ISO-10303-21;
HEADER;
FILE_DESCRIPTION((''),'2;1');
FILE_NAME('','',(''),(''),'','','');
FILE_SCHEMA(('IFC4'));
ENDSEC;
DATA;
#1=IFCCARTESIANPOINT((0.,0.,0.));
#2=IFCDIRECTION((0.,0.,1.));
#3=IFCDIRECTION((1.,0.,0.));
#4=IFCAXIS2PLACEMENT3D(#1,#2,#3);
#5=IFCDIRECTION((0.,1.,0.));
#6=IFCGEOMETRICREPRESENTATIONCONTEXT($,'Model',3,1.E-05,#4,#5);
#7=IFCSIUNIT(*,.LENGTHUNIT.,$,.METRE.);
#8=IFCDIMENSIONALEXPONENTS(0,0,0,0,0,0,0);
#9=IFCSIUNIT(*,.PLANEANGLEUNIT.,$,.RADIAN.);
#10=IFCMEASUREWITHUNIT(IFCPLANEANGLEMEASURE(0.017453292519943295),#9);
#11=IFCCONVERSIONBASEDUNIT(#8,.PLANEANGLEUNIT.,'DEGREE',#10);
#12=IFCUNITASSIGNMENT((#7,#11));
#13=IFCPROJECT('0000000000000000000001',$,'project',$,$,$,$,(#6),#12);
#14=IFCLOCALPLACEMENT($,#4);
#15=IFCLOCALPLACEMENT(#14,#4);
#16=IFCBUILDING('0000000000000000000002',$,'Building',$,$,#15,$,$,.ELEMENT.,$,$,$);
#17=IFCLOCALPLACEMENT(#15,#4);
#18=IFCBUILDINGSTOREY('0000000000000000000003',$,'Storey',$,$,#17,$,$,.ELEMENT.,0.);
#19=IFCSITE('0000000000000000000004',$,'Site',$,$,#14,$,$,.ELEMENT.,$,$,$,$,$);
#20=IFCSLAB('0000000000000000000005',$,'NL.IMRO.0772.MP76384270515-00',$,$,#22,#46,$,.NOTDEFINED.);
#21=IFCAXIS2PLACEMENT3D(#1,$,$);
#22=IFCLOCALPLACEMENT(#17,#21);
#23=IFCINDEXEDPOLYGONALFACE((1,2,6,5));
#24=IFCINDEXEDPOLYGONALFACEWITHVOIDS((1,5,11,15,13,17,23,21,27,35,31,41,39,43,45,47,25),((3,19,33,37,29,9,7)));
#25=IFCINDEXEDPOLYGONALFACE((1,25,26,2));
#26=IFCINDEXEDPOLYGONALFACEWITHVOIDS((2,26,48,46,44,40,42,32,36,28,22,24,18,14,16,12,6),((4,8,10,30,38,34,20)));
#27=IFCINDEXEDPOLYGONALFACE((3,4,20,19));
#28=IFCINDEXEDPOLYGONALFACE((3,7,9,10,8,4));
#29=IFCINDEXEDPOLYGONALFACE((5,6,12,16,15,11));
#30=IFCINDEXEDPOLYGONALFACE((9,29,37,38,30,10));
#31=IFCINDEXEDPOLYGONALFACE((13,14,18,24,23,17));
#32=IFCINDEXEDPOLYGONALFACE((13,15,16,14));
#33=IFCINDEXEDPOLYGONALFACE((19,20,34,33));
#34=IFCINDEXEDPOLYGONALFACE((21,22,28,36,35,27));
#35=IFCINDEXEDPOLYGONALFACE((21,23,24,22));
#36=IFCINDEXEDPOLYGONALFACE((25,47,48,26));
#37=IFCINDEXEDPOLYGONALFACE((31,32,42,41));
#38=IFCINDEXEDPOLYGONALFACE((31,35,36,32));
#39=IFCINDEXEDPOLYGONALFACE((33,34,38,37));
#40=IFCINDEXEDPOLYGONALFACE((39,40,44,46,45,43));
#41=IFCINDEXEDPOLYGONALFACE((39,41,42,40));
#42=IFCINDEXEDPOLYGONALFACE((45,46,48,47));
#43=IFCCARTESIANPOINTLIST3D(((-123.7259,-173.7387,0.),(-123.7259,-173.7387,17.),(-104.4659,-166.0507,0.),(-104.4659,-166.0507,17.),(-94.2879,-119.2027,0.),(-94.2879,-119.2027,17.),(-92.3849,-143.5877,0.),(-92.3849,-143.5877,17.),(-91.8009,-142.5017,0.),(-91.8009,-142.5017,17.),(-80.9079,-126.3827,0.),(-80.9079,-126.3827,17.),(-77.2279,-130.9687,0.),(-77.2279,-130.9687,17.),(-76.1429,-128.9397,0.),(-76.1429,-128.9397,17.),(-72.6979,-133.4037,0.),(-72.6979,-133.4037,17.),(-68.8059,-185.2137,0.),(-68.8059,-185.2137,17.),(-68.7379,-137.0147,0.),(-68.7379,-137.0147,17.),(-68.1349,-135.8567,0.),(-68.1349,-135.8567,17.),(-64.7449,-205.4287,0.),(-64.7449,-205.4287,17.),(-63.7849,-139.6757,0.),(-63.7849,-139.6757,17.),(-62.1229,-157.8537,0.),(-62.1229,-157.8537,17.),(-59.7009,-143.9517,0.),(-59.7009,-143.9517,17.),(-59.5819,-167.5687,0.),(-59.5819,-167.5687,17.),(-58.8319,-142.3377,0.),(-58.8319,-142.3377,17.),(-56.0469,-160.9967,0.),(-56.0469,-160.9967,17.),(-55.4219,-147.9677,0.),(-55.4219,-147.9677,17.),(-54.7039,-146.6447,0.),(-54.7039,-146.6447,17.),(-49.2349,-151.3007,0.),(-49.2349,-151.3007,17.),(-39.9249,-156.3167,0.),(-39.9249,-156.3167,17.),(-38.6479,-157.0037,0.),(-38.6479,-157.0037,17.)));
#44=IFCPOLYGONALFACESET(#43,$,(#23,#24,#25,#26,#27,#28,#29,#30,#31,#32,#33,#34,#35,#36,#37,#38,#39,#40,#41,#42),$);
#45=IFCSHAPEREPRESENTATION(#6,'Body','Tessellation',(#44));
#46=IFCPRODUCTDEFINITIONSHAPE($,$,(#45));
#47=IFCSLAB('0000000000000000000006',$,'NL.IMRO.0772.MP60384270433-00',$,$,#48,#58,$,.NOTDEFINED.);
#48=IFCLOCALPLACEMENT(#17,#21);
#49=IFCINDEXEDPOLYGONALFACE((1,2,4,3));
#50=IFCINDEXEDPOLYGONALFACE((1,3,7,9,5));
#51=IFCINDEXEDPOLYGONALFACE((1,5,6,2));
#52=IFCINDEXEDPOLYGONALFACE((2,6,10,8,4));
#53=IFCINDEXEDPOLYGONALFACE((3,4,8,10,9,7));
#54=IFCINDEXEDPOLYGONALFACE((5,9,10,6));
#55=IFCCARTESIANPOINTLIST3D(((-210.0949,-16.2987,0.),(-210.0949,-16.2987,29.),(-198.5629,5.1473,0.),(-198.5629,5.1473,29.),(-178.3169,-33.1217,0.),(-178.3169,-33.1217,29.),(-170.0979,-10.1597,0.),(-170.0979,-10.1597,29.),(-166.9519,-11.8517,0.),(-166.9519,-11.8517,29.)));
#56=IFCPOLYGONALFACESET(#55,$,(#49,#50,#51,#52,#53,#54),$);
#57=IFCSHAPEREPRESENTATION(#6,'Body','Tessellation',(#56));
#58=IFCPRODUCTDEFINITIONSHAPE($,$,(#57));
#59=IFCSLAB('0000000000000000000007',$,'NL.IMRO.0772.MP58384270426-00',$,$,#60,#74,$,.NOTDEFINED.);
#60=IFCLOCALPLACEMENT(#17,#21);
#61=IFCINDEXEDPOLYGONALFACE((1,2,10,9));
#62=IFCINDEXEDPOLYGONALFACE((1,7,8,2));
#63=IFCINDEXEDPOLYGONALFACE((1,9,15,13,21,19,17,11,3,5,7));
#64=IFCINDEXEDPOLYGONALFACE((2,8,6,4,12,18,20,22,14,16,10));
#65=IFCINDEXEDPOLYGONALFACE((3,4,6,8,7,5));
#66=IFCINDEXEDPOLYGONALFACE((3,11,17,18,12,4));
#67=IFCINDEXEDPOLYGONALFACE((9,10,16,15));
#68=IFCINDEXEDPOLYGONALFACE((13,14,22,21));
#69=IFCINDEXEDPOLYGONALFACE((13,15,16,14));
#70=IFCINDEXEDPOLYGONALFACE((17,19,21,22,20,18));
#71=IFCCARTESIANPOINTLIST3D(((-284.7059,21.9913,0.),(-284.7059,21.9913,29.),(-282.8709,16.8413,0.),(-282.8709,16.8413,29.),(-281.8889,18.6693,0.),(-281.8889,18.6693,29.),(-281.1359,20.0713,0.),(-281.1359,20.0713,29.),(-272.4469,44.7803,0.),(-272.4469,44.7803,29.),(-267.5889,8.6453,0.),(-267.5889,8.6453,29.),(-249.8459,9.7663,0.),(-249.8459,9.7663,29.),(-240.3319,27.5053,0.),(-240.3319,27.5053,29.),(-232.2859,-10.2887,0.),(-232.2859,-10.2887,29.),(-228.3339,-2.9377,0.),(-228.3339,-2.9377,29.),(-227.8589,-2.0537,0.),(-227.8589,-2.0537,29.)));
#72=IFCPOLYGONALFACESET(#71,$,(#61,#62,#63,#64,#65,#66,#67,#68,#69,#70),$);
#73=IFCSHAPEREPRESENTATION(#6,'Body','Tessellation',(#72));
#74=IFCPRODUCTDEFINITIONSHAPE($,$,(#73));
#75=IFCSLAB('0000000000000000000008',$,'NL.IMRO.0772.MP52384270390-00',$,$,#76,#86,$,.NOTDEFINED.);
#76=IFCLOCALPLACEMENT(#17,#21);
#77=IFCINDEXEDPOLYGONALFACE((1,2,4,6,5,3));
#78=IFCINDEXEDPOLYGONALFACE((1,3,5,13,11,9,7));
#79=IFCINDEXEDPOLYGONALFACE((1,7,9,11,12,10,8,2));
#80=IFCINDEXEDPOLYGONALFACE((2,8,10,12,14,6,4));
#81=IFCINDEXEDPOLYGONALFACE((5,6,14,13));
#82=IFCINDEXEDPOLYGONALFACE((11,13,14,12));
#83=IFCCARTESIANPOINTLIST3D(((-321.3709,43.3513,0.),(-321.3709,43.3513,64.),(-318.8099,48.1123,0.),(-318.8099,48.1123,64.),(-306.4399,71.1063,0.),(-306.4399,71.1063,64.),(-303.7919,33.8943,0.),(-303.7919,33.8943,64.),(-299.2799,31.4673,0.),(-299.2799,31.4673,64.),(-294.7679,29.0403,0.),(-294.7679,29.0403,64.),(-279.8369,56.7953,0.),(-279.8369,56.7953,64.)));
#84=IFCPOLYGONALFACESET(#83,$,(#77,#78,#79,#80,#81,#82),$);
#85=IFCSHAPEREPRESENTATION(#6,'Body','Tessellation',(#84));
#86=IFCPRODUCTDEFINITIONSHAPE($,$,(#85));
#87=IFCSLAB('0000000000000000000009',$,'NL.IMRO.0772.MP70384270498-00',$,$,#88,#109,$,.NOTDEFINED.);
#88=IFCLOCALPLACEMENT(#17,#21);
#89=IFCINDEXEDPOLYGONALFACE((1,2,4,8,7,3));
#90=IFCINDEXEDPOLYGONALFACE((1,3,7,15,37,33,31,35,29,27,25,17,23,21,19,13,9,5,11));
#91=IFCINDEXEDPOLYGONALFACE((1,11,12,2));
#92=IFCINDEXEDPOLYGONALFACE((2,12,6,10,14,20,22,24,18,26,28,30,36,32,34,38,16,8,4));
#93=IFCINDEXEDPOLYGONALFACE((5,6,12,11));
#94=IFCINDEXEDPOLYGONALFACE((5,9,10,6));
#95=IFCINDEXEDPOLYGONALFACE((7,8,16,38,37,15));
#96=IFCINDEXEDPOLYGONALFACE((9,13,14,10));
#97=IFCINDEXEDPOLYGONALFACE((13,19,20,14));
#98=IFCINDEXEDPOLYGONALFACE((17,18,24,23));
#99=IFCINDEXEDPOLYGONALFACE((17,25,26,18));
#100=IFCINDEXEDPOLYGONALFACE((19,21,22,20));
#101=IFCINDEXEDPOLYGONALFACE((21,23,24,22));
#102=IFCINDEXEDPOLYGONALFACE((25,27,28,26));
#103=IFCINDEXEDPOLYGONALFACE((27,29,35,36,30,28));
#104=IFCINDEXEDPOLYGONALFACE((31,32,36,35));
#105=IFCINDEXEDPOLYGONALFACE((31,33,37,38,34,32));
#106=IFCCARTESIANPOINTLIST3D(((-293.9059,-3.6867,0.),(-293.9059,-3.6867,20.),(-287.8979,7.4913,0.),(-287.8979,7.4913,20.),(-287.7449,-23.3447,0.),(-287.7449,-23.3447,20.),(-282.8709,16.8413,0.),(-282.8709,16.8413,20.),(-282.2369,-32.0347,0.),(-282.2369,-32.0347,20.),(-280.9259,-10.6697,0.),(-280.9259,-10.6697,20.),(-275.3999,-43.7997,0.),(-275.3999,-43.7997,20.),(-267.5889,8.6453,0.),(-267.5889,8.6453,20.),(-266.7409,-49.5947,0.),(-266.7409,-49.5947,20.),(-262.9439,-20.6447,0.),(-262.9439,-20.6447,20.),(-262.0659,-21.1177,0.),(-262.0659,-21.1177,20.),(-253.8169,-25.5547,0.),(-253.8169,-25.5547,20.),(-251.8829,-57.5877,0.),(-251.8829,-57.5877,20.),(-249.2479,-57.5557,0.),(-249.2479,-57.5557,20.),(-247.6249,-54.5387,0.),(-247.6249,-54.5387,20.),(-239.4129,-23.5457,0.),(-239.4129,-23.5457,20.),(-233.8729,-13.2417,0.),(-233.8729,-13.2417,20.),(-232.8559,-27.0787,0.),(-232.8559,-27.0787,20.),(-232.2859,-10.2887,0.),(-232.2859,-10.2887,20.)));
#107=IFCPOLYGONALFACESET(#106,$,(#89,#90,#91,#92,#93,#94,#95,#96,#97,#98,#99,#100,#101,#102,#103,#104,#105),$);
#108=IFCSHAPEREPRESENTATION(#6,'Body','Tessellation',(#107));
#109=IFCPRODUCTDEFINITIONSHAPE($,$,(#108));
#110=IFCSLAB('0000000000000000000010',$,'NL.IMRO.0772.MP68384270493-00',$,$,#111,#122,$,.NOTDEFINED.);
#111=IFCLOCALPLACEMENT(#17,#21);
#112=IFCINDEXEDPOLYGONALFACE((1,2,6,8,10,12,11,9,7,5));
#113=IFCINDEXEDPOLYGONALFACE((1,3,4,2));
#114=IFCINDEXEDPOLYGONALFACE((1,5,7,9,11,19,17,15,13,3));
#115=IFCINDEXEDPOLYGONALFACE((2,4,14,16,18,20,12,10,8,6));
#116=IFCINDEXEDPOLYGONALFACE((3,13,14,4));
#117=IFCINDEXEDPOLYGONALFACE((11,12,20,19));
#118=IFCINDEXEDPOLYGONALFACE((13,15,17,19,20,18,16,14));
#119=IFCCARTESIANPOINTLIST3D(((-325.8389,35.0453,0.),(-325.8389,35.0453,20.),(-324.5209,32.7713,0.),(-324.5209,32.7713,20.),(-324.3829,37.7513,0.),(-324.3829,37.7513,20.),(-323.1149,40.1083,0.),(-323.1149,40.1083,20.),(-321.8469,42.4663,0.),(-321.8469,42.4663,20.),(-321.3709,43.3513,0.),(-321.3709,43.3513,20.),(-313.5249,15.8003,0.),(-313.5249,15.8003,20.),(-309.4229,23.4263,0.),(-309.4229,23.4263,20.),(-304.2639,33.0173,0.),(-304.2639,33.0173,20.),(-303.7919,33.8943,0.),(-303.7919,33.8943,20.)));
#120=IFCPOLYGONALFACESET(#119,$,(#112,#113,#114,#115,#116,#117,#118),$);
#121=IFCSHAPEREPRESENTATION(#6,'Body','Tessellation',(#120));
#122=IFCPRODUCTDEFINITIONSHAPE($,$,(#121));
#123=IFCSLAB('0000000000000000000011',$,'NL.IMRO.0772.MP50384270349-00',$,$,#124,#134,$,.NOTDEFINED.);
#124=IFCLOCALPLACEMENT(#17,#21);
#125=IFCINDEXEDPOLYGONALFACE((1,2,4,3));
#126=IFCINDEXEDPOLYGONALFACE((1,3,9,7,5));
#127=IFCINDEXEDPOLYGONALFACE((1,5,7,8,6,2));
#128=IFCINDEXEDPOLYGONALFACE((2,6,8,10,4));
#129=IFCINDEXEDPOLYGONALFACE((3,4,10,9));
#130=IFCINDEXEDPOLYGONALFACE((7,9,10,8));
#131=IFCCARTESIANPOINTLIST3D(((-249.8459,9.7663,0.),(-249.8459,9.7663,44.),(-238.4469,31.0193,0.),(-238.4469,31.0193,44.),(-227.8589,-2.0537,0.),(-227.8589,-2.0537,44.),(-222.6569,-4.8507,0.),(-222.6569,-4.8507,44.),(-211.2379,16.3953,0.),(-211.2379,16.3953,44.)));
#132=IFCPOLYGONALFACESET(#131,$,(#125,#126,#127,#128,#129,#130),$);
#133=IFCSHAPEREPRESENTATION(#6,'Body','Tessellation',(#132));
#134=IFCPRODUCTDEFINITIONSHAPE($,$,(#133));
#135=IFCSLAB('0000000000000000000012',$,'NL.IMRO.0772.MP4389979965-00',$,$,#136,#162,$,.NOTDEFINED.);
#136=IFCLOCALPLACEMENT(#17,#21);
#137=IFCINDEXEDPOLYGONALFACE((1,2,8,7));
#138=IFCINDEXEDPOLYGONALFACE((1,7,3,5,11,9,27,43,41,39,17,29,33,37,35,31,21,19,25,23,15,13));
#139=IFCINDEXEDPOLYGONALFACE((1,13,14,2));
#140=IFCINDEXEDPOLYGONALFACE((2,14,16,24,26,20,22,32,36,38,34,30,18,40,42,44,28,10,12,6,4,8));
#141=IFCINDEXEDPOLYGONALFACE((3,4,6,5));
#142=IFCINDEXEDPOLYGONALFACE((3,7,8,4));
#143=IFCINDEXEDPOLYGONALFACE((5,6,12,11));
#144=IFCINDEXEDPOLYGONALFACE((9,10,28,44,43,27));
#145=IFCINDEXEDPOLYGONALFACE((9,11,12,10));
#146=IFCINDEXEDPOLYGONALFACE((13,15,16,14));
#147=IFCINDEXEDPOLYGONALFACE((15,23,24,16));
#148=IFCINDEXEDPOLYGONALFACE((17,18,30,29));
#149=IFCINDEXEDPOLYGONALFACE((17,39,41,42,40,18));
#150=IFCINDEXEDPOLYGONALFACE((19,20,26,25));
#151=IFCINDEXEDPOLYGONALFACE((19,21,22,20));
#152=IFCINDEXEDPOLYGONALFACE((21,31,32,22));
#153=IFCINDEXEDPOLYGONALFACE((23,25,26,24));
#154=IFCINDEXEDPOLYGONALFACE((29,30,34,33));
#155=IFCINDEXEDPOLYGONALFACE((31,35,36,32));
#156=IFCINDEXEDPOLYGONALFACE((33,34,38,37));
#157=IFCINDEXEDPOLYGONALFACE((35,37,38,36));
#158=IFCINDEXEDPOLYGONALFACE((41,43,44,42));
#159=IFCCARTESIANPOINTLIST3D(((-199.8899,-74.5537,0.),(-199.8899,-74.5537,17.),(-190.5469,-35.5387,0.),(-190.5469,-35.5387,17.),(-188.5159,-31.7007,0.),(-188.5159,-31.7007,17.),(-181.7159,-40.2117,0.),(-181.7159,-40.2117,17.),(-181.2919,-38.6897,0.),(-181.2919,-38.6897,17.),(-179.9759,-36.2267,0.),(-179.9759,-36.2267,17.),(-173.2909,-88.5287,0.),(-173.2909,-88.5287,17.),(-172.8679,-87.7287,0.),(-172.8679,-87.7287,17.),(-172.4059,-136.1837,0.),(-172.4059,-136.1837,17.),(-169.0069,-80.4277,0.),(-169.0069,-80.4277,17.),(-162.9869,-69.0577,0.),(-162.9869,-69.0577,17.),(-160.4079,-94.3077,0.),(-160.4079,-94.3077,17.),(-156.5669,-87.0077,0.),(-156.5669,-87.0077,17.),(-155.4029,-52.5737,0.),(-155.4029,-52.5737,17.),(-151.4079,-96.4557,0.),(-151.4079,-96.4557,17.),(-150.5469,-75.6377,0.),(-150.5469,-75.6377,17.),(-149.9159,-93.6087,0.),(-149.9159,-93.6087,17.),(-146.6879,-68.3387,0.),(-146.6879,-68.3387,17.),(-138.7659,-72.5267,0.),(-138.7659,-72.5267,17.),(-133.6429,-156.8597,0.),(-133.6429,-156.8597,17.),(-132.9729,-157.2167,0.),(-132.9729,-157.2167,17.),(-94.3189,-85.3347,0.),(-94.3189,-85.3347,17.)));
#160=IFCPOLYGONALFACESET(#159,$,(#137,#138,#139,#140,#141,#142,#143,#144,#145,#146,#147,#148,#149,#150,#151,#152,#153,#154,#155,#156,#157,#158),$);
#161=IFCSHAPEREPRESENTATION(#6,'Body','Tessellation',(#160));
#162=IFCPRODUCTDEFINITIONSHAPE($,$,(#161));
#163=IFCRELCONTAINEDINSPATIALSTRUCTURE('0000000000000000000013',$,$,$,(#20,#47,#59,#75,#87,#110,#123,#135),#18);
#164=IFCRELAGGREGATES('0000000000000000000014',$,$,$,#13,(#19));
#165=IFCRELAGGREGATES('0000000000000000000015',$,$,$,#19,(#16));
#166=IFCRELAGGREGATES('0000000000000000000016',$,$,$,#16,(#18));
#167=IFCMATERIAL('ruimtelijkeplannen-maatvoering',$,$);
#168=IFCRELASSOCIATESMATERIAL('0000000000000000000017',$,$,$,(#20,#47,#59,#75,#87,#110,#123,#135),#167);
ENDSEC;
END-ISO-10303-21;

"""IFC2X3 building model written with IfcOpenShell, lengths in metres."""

from ifc_helpers import new_model, entity, si_unit, converted_unit, direction, origin_with_axes, place, context, project, spatial, polyline, outline, extrude, material, element, save


model = new_model("IFC2X3")

# Units and contexts
model_context = context("Model", 3, precision=1e-05, world=origin_with_axes(), true_north=direction((0.0, 1.0, 0.0)))
ifc_project = project(units=[si_unit("LENGTHUNIT", "METRE"), converted_unit("PLANEANGLEUNIT", "DEGREE", entity("IfcPlaneAngleMeasure", 0.017453292519943295), si_unit("PLANEANGLEUNIT", "RADIAN"), dimensions=[0, 0, 0, 0, 0, 0, 0])], contexts=[model_context])

# Site, building, storey
site_placement = place(None, origin_with_axes())
site = spatial("IfcSite", under=ifc_project, at=site_placement, Name="Site", CompositionType="ELEMENT")
building_placement = place(site_placement, origin_with_axes())
building = spatial("IfcBuilding", under=site, at=building_placement, Name="Building", CompositionType="ELEMENT")
storey_placement = place(building_placement, origin_with_axes())
storey = spatial("IfcBuildingStorey", under=building, at=storey_placement, Name="Storey", CompositionType="ELEMENT", Elevation=0.0)

# Slabs
ifc_material = material(Name="ruimtelijkeplannen-maatvoering")
slab_1_placement = place(storey_placement, origin_with_axes())
element("IfcSlab", 1, at=slab_1_placement, inside=storey, material=ifc_material, Name="NL.IMRO.0772.MP76384270515-00", PredefinedType="NOTDEFINED", context=model_context, shape_type="SweptSolid", body=[
    extrude(outline(polyline([(-123.7259, -173.7387), (-94.2879, -119.2027), (-80.9079, -126.3827), (-76.1429, -128.9397), (-77.2279, -130.9687), (-72.6979, -133.4037), (-68.1349, -135.8567), (-68.7379, -137.0147), (-63.7849, -139.6757), (-58.8319, -142.3377), (-59.7009, -143.9517), (-54.7039, -146.6447), (-55.4219, -147.9677), (-49.2349, -151.3007), (-39.9249, -156.3167), (-38.6479, -157.0037), (-64.7449, -205.4287), (-123.7259, -173.7387)]), holes=[polyline([(-92.3849, -143.5877), (-104.4659, -166.0507), (-68.8059, -185.2137), (-59.5819, -167.5687), (-56.0469, -160.9967), (-62.1229, -157.8537), (-91.8009, -142.5017), (-92.3849, -143.5877)])]), origin_with_axes(), (0.0, 0.0, 1.0), 17.0),
])
slab_2_placement = place(storey_placement, origin_with_axes())
element("IfcSlab", 2, at=slab_2_placement, inside=storey, material=ifc_material, Name="NL.IMRO.0772.MP60384270433-00", PredefinedType="NOTDEFINED", context=model_context, shape_type="SweptSolid", body=[
    extrude(outline(polyline([(-178.3169, -33.1217), (-210.0949, -16.2987), (-198.5629, 5.1473), (-170.0979, -10.1597), (-166.9519, -11.8517), (-178.3169, -33.1217)])), origin_with_axes(), (0.0, 0.0, 1.0), 29.0),
])
slab_3_placement = place(storey_placement, origin_with_axes())
element("IfcSlab", 3, at=slab_3_placement, inside=storey, material=ifc_material, Name="NL.IMRO.0772.MP58384270426-00", PredefinedType="NOTDEFINED", context=model_context, shape_type="SweptSolid", body=[
    extrude(outline(polyline([(-282.8709, 16.8413), (-281.8889, 18.6693), (-281.1359, 20.0713), (-284.7059, 21.9913), (-272.4469, 44.7803), (-240.3319, 27.5053), (-249.8459, 9.7663), (-227.8589, -2.0537), (-228.3339, -2.9377), (-232.2859, -10.2887), (-267.5889, 8.6453), (-282.8709, 16.8413)])), origin_with_axes(), (0.0, 0.0, 1.0), 29.0),
])
slab_4_placement = place(storey_placement, origin_with_axes())
element("IfcSlab", 4, at=slab_4_placement, inside=storey, material=ifc_material, Name="NL.IMRO.0772.MP52384270390-00", PredefinedType="NOTDEFINED", context=model_context, shape_type="SweptSolid", body=[
    extrude(outline(polyline([(-306.4399, 71.1063), (-279.8369, 56.7953), (-294.7679, 29.0403), (-299.2799, 31.4673), (-303.7919, 33.8943), (-321.3709, 43.3513), (-318.8099, 48.1123), (-306.4399, 71.1063)])), origin_with_axes(), (0.0, 0.0, 1.0), 64.0),
])
slab_5_placement = place(storey_placement, origin_with_axes())
element("IfcSlab", 5, at=slab_5_placement, inside=storey, material=ifc_material, Name="NL.IMRO.0772.MP70384270498-00", PredefinedType="NOTDEFINED", context=model_context, shape_type="SweptSolid", body=[
    extrude(outline(polyline([(-232.2859, -10.2887), (-233.8729, -13.2417), (-239.4129, -23.5457), (-232.8559, -27.0787), (-247.6249, -54.5387), (-249.2479, -57.5557), (-251.8829, -57.5877), (-266.7409, -49.5947), (-253.8169, -25.5547), (-262.0659, -21.1177), (-262.9439, -20.6447), (-275.3999, -43.7997), (-282.2369, -32.0347), (-287.7449, -23.3447), (-280.9259, -10.6697), (-293.9059, -3.6867), (-287.8979, 7.4913), (-282.8709, 16.8413), (-267.5889, 8.6453), (-232.2859, -10.2887)])), origin_with_axes(), (0.0, 0.0, 1.0), 20.0),
])
slab_6_placement = place(storey_placement, origin_with_axes())
element("IfcSlab", 6, at=slab_6_placement, inside=storey, material=ifc_material, Name="NL.IMRO.0772.MP68384270493-00", PredefinedType="NOTDEFINED", context=model_context, shape_type="SweptSolid", body=[
    extrude(outline(polyline([(-321.3709, 43.3513), (-303.7919, 33.8943), (-304.2639, 33.0173), (-309.4229, 23.4263), (-313.5249, 15.8003), (-324.5209, 32.7713), (-325.8389, 35.0453), (-324.3829, 37.7513), (-323.1149, 40.1083), (-321.8469, 42.4663), (-321.3709, 43.3513)])), origin_with_axes(), (0.0, 0.0, 1.0), 20.0),
])
slab_7_placement = place(storey_placement, origin_with_axes())
element("IfcSlab", 7, at=slab_7_placement, inside=storey, material=ifc_material, Name="NL.IMRO.0772.MP50384270349-00", PredefinedType="NOTDEFINED", context=model_context, shape_type="SweptSolid", body=[
    extrude(outline(polyline([(-238.4469, 31.0193), (-211.2379, 16.3953), (-222.6569, -4.8507), (-227.8589, -2.0537), (-249.8459, 9.7663), (-238.4469, 31.0193)])), origin_with_axes(), (0.0, 0.0, 1.0), 44.0),
])
slab_8_placement = place(storey_placement, origin_with_axes())
element("IfcSlab", 8, at=slab_8_placement, inside=storey, material=ifc_material, Name="NL.IMRO.0772.MP4389979965-00", PredefinedType="NOTDEFINED", context=model_context, shape_type="SweptSolid", body=[
    extrude(outline(polyline([(-138.7659, -72.5267), (-146.6879, -68.3387), (-150.5469, -75.6377), (-162.9869, -69.0577), (-169.0069, -80.4277), (-156.5669, -87.0077), (-160.4079, -94.3077), (-172.8679, -87.7287), (-173.2909, -88.5287), (-199.8899, -74.5537), (-181.7159, -40.2117), (-190.5469, -35.5387), (-188.5159, -31.7007), (-179.9759, -36.2267), (-181.2919, -38.6897), (-155.4029, -52.5737), (-94.3189, -85.3347), (-132.9729, -157.2167), (-133.6429, -156.8597), (-172.4059, -136.1837), (-151.4079, -96.4557), (-149.9159, -93.6087), (-138.7659, -72.5267)])), origin_with_axes(), (0.0, 0.0, 1.0), 17.0),
])

save(model, "model.ifc")
